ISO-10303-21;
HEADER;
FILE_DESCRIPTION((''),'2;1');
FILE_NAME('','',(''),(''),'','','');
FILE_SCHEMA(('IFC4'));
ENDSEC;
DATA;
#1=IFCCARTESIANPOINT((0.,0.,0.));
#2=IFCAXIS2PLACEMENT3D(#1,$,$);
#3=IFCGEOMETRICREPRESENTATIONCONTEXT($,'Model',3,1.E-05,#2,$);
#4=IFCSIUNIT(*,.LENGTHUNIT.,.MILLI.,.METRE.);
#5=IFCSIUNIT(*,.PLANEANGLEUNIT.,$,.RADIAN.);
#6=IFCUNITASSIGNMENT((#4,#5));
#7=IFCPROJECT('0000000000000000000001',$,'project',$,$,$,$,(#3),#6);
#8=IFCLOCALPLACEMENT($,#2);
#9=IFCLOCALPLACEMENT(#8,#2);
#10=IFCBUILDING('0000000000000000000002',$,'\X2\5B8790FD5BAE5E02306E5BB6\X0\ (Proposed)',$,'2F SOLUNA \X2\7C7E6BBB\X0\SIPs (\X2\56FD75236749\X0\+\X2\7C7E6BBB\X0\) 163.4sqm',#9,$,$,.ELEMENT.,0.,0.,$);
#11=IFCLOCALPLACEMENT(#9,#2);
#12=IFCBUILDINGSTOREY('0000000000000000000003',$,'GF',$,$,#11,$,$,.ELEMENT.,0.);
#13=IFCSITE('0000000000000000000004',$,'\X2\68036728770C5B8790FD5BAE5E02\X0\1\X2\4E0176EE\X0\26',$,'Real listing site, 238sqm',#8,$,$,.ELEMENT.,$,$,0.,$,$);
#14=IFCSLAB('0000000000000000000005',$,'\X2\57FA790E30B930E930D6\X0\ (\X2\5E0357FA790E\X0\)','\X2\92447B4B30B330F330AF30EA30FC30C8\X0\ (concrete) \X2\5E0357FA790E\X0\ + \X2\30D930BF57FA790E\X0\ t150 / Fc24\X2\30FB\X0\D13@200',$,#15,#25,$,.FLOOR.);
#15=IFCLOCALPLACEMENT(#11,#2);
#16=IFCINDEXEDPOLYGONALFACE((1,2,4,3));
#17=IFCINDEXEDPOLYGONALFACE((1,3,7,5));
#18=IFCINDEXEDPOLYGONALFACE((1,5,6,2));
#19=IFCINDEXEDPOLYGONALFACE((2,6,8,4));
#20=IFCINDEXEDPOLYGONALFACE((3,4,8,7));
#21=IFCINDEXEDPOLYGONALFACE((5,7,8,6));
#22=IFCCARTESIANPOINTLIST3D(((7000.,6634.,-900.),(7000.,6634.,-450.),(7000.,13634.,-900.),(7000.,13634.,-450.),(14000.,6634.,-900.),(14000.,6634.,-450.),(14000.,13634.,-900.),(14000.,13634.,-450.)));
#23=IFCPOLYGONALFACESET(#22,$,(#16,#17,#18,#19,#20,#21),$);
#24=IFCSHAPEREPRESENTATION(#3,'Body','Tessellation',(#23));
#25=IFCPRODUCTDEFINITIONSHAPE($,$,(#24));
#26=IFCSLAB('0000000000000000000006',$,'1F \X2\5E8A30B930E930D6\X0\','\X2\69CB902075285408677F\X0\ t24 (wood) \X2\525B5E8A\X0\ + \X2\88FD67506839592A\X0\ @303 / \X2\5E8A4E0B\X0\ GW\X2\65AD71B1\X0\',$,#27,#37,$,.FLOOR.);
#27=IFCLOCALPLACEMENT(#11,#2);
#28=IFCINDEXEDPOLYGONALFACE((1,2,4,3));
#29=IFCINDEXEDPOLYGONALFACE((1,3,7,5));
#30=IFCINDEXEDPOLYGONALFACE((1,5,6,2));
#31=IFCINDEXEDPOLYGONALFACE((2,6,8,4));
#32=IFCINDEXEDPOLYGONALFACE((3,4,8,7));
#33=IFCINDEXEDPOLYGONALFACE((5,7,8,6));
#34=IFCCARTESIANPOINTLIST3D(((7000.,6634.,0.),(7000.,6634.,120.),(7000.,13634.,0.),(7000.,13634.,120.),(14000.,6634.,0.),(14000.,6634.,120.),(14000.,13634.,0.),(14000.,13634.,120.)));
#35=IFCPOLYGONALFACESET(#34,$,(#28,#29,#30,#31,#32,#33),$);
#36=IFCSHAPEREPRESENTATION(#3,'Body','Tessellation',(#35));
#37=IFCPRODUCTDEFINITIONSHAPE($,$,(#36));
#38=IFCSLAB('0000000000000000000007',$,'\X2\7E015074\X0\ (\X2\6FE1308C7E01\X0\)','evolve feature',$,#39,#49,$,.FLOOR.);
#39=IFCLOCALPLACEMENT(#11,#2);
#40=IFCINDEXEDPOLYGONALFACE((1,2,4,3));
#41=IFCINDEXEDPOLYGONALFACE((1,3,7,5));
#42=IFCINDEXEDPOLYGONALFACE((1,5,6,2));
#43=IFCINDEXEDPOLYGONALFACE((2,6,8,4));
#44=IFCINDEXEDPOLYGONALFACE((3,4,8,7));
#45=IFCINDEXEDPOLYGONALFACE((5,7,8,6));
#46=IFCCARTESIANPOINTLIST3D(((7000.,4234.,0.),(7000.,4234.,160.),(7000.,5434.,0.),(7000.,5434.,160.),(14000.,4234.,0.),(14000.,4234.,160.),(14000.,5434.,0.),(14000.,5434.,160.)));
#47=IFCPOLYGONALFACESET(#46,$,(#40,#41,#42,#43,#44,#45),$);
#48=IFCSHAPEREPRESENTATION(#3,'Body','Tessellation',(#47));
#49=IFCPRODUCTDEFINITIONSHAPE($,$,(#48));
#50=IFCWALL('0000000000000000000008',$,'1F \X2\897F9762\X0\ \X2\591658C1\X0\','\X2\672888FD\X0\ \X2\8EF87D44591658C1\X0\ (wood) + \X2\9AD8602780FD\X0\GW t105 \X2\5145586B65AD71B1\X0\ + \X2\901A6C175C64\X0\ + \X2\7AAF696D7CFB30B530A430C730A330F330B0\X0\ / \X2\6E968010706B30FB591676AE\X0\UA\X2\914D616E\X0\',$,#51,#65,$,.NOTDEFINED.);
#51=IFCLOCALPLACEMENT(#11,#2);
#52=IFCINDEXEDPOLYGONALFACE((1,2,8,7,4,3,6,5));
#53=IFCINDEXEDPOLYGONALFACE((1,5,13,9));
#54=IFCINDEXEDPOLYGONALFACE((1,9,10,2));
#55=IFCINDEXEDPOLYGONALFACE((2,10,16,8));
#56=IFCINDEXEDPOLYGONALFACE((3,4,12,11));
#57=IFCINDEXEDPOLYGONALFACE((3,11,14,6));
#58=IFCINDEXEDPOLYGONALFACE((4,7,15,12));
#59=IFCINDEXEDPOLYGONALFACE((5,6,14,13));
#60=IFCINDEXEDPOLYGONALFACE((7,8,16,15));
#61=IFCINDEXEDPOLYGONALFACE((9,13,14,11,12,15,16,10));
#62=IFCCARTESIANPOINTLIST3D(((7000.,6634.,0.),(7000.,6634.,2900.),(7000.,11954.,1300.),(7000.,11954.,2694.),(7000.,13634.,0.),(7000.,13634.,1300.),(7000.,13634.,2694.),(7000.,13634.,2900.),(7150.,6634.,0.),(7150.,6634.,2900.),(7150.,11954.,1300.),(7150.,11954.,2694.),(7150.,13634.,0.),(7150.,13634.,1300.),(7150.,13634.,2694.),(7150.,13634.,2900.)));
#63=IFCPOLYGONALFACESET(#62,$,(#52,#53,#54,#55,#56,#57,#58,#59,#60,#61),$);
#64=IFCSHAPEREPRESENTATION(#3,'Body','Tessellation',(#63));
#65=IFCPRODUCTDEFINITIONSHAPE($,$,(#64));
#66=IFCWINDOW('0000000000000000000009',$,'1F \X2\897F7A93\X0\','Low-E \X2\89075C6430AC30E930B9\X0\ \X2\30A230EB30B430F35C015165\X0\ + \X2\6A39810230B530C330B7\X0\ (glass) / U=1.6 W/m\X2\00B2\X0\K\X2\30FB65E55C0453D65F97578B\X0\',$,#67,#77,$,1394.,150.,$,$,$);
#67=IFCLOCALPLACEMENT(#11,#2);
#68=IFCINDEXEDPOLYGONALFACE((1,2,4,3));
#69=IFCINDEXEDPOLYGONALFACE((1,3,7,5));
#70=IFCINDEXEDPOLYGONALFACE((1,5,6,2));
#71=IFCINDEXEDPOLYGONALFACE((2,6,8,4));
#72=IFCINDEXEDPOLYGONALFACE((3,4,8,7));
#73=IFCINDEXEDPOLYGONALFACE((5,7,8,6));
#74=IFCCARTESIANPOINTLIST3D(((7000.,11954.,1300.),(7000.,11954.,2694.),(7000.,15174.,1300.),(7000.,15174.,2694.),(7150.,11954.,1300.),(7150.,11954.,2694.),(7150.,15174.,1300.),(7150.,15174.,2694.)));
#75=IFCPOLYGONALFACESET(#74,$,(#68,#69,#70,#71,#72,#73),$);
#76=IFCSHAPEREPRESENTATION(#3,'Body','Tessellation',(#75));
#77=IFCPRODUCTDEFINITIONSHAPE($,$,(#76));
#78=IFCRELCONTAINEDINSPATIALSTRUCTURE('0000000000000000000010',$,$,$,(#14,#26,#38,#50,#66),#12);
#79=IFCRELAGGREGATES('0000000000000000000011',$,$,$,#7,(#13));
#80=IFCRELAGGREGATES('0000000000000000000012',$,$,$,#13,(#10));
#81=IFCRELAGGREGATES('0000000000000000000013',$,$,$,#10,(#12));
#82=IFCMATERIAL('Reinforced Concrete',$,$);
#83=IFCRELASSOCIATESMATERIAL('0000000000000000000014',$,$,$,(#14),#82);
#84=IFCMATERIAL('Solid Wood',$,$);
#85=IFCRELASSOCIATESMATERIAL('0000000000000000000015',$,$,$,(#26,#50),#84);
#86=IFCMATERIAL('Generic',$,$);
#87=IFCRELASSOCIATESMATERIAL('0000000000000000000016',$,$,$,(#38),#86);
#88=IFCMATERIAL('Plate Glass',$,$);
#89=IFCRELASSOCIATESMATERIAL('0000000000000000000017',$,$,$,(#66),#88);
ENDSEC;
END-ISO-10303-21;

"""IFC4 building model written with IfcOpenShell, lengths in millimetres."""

from ifc_helpers import new_model, si_unit, frame, frame_2d, origin, place, context, project, spatial, rectangle, extrude, material, element, fill, save


model = new_model("IFC4")

# Units and contexts
model_context = context("Model", 3, precision=1e-05, world=origin())
ifc_project = project(units=[si_unit("LENGTHUNIT", "METRE", prefix="MILLI"), si_unit("PLANEANGLEUNIT", "RADIAN")], contexts=[model_context])

# Site, building, storey
site_placement = place(None, origin())
site = spatial("IfcSite", under=ifc_project, at=site_placement, Name="栃木県宇都宮市1丁目26", ObjectType="Real listing site, 238sqm", CompositionType="ELEMENT", RefElevation=0.0)
building_placement = place(site_placement, origin())
building = spatial("IfcBuilding", under=site, at=building_placement, Name="宇都宮市の家 (Proposed)", ObjectType="2F SOLUNA 籾殻SIPs (国産杉+籾殻) 163.4sqm", CompositionType="ELEMENT", ElevationOfRefHeight=0.0, ElevationOfTerrain=0.0)
storey_placement = place(building_placement, origin())
storey = spatial("IfcBuildingStorey", under=building, at=storey_placement, Name="GF", CompositionType="ELEMENT", Elevation=0.0)

# Slabs
ifc_material_1 = material(Name="Reinforced Concrete")
slab_1_placement = place(storey_placement, frame((3500.0, 3317.0, -450.0)))
element("IfcSlab", 1, at=slab_1_placement, inside=storey, material=ifc_material_1, Name="基礎スラブ (布基礎)", Description="鉄筋コンクリート (concrete) 布基礎 + ベタ基礎 t150 / Fc24・D13@200", PredefinedType="FLOOR", context=model_context, shape_type="SweptSolid", body=[
    extrude(rectangle(XDim=7000.0, YDim=7000.0, at=frame_2d((3500.0, 3500.0))), frame((3500.0, 3317.0, -450.0)), (0.0, 0.0, 1.0), 450.0),
])
ifc_material_2 = material(Name="Solid Wood")
slab_2_placement = place(storey_placement, frame((3500.0, 3317.0, 0.0)))
element("IfcSlab", 2, at=slab_2_placement, inside=storey, material=ifc_material_2, Name="1F 床スラブ", Description="構造用合板 t24 (wood) 剛床 + 製材根太 @303 / 床下 GW断熱", PredefinedType="FLOOR", context=model_context, shape_type="SweptSolid", body=[
    extrude(rectangle(XDim=7000.0, YDim=7000.0, at=frame_2d((3500.0, 3500.0))), frame((3500.0, 3317.0, 0.0)), (0.0, 0.0, 1.0), 120.0),
])
ifc_material_3 = material(Name="Generic")
slab_3_placement = place(storey_placement, frame((3500.0, 2117.0, 0.0)))
element("IfcSlab", 3, at=slab_3_placement, inside=storey, material=ifc_material_3, Name="縁側 (濡れ縁)", Description="evolve feature", PredefinedType="FLOOR", context=model_context, shape_type="SweptSolid", body=[
    extrude(rectangle(XDim=7000.0, YDim=1200.0, at=frame_2d((3500.0, 600.0))), frame((3500.0, 2117.0, 0.0)), (0.0, 0.0, 1.0), 160.0),
])

# Shared definitions
ifc_material_4 = material(Name="Plate Glass")

# Wall, opening, window
wall_1_placement = place(storey_placement, frame((3500.0, 3317.0, 0.0)))
wall_1 = element("IfcWall", 4, at=wall_1_placement, inside=storey, material=ifc_material_2, Name="1F 西面 外壁", Description="木製 軸組外壁 (wood) + 高性能GW t105 充填断熱 + 通気層 + 窯業系サイディング / 準耐火・外皮UA配慮", PredefinedType="NOTDEFINED", context=model_context, shape_type="SweptSolid", body=[
    extrude(rectangle(XDim=150.0, YDim=7000.0, at=frame_2d((75.0, 3500.0))), frame((3500.0, 3317.0, 0.0)), (0.0, 0.0, 1.0), 2900.0),
])
opening_1_placement = place(storey_placement, frame((3500.0, 5977.0, 650.0)))
opening_1 = element("IfcOpeningElement", 5, at=opening_1_placement, cuts=wall_1, PredefinedType="NOTDEFINED", context=model_context, shape_type="SweptSolid", body=[
    extrude(rectangle(XDim=150.0, YDim=3220.0, at=frame_2d((75.0, 1610.0))), frame((3500.0, 5977.0, 650.0)), (0.0, 0.0, 1.0), 1394.0),
])
window_1_placement = place(storey_placement, frame((3500.0, 5977.0, 650.0)))
window_1 = element("IfcWindow", 6, at=window_1_placement, inside=storey, material=ifc_material_4, Name="1F 西窓", Description="Low-E 複層ガラス アルゴン封入 + 樹脂サッシ (glass) / U=1.6 W/m²K・日射取得型", OverallHeight=1394.0, OverallWidth=150.0, context=model_context, shape_type="SweptSolid", body=[
    extrude(rectangle(XDim=150.0, YDim=3220.0, at=frame_2d((75.0, 1610.0))), frame((3500.0, 5977.0, 650.0)), (0.0, 0.0, 1.0), 1394.0),
])
fill(opening_1, window_1)

save(model, "model.ifc")
